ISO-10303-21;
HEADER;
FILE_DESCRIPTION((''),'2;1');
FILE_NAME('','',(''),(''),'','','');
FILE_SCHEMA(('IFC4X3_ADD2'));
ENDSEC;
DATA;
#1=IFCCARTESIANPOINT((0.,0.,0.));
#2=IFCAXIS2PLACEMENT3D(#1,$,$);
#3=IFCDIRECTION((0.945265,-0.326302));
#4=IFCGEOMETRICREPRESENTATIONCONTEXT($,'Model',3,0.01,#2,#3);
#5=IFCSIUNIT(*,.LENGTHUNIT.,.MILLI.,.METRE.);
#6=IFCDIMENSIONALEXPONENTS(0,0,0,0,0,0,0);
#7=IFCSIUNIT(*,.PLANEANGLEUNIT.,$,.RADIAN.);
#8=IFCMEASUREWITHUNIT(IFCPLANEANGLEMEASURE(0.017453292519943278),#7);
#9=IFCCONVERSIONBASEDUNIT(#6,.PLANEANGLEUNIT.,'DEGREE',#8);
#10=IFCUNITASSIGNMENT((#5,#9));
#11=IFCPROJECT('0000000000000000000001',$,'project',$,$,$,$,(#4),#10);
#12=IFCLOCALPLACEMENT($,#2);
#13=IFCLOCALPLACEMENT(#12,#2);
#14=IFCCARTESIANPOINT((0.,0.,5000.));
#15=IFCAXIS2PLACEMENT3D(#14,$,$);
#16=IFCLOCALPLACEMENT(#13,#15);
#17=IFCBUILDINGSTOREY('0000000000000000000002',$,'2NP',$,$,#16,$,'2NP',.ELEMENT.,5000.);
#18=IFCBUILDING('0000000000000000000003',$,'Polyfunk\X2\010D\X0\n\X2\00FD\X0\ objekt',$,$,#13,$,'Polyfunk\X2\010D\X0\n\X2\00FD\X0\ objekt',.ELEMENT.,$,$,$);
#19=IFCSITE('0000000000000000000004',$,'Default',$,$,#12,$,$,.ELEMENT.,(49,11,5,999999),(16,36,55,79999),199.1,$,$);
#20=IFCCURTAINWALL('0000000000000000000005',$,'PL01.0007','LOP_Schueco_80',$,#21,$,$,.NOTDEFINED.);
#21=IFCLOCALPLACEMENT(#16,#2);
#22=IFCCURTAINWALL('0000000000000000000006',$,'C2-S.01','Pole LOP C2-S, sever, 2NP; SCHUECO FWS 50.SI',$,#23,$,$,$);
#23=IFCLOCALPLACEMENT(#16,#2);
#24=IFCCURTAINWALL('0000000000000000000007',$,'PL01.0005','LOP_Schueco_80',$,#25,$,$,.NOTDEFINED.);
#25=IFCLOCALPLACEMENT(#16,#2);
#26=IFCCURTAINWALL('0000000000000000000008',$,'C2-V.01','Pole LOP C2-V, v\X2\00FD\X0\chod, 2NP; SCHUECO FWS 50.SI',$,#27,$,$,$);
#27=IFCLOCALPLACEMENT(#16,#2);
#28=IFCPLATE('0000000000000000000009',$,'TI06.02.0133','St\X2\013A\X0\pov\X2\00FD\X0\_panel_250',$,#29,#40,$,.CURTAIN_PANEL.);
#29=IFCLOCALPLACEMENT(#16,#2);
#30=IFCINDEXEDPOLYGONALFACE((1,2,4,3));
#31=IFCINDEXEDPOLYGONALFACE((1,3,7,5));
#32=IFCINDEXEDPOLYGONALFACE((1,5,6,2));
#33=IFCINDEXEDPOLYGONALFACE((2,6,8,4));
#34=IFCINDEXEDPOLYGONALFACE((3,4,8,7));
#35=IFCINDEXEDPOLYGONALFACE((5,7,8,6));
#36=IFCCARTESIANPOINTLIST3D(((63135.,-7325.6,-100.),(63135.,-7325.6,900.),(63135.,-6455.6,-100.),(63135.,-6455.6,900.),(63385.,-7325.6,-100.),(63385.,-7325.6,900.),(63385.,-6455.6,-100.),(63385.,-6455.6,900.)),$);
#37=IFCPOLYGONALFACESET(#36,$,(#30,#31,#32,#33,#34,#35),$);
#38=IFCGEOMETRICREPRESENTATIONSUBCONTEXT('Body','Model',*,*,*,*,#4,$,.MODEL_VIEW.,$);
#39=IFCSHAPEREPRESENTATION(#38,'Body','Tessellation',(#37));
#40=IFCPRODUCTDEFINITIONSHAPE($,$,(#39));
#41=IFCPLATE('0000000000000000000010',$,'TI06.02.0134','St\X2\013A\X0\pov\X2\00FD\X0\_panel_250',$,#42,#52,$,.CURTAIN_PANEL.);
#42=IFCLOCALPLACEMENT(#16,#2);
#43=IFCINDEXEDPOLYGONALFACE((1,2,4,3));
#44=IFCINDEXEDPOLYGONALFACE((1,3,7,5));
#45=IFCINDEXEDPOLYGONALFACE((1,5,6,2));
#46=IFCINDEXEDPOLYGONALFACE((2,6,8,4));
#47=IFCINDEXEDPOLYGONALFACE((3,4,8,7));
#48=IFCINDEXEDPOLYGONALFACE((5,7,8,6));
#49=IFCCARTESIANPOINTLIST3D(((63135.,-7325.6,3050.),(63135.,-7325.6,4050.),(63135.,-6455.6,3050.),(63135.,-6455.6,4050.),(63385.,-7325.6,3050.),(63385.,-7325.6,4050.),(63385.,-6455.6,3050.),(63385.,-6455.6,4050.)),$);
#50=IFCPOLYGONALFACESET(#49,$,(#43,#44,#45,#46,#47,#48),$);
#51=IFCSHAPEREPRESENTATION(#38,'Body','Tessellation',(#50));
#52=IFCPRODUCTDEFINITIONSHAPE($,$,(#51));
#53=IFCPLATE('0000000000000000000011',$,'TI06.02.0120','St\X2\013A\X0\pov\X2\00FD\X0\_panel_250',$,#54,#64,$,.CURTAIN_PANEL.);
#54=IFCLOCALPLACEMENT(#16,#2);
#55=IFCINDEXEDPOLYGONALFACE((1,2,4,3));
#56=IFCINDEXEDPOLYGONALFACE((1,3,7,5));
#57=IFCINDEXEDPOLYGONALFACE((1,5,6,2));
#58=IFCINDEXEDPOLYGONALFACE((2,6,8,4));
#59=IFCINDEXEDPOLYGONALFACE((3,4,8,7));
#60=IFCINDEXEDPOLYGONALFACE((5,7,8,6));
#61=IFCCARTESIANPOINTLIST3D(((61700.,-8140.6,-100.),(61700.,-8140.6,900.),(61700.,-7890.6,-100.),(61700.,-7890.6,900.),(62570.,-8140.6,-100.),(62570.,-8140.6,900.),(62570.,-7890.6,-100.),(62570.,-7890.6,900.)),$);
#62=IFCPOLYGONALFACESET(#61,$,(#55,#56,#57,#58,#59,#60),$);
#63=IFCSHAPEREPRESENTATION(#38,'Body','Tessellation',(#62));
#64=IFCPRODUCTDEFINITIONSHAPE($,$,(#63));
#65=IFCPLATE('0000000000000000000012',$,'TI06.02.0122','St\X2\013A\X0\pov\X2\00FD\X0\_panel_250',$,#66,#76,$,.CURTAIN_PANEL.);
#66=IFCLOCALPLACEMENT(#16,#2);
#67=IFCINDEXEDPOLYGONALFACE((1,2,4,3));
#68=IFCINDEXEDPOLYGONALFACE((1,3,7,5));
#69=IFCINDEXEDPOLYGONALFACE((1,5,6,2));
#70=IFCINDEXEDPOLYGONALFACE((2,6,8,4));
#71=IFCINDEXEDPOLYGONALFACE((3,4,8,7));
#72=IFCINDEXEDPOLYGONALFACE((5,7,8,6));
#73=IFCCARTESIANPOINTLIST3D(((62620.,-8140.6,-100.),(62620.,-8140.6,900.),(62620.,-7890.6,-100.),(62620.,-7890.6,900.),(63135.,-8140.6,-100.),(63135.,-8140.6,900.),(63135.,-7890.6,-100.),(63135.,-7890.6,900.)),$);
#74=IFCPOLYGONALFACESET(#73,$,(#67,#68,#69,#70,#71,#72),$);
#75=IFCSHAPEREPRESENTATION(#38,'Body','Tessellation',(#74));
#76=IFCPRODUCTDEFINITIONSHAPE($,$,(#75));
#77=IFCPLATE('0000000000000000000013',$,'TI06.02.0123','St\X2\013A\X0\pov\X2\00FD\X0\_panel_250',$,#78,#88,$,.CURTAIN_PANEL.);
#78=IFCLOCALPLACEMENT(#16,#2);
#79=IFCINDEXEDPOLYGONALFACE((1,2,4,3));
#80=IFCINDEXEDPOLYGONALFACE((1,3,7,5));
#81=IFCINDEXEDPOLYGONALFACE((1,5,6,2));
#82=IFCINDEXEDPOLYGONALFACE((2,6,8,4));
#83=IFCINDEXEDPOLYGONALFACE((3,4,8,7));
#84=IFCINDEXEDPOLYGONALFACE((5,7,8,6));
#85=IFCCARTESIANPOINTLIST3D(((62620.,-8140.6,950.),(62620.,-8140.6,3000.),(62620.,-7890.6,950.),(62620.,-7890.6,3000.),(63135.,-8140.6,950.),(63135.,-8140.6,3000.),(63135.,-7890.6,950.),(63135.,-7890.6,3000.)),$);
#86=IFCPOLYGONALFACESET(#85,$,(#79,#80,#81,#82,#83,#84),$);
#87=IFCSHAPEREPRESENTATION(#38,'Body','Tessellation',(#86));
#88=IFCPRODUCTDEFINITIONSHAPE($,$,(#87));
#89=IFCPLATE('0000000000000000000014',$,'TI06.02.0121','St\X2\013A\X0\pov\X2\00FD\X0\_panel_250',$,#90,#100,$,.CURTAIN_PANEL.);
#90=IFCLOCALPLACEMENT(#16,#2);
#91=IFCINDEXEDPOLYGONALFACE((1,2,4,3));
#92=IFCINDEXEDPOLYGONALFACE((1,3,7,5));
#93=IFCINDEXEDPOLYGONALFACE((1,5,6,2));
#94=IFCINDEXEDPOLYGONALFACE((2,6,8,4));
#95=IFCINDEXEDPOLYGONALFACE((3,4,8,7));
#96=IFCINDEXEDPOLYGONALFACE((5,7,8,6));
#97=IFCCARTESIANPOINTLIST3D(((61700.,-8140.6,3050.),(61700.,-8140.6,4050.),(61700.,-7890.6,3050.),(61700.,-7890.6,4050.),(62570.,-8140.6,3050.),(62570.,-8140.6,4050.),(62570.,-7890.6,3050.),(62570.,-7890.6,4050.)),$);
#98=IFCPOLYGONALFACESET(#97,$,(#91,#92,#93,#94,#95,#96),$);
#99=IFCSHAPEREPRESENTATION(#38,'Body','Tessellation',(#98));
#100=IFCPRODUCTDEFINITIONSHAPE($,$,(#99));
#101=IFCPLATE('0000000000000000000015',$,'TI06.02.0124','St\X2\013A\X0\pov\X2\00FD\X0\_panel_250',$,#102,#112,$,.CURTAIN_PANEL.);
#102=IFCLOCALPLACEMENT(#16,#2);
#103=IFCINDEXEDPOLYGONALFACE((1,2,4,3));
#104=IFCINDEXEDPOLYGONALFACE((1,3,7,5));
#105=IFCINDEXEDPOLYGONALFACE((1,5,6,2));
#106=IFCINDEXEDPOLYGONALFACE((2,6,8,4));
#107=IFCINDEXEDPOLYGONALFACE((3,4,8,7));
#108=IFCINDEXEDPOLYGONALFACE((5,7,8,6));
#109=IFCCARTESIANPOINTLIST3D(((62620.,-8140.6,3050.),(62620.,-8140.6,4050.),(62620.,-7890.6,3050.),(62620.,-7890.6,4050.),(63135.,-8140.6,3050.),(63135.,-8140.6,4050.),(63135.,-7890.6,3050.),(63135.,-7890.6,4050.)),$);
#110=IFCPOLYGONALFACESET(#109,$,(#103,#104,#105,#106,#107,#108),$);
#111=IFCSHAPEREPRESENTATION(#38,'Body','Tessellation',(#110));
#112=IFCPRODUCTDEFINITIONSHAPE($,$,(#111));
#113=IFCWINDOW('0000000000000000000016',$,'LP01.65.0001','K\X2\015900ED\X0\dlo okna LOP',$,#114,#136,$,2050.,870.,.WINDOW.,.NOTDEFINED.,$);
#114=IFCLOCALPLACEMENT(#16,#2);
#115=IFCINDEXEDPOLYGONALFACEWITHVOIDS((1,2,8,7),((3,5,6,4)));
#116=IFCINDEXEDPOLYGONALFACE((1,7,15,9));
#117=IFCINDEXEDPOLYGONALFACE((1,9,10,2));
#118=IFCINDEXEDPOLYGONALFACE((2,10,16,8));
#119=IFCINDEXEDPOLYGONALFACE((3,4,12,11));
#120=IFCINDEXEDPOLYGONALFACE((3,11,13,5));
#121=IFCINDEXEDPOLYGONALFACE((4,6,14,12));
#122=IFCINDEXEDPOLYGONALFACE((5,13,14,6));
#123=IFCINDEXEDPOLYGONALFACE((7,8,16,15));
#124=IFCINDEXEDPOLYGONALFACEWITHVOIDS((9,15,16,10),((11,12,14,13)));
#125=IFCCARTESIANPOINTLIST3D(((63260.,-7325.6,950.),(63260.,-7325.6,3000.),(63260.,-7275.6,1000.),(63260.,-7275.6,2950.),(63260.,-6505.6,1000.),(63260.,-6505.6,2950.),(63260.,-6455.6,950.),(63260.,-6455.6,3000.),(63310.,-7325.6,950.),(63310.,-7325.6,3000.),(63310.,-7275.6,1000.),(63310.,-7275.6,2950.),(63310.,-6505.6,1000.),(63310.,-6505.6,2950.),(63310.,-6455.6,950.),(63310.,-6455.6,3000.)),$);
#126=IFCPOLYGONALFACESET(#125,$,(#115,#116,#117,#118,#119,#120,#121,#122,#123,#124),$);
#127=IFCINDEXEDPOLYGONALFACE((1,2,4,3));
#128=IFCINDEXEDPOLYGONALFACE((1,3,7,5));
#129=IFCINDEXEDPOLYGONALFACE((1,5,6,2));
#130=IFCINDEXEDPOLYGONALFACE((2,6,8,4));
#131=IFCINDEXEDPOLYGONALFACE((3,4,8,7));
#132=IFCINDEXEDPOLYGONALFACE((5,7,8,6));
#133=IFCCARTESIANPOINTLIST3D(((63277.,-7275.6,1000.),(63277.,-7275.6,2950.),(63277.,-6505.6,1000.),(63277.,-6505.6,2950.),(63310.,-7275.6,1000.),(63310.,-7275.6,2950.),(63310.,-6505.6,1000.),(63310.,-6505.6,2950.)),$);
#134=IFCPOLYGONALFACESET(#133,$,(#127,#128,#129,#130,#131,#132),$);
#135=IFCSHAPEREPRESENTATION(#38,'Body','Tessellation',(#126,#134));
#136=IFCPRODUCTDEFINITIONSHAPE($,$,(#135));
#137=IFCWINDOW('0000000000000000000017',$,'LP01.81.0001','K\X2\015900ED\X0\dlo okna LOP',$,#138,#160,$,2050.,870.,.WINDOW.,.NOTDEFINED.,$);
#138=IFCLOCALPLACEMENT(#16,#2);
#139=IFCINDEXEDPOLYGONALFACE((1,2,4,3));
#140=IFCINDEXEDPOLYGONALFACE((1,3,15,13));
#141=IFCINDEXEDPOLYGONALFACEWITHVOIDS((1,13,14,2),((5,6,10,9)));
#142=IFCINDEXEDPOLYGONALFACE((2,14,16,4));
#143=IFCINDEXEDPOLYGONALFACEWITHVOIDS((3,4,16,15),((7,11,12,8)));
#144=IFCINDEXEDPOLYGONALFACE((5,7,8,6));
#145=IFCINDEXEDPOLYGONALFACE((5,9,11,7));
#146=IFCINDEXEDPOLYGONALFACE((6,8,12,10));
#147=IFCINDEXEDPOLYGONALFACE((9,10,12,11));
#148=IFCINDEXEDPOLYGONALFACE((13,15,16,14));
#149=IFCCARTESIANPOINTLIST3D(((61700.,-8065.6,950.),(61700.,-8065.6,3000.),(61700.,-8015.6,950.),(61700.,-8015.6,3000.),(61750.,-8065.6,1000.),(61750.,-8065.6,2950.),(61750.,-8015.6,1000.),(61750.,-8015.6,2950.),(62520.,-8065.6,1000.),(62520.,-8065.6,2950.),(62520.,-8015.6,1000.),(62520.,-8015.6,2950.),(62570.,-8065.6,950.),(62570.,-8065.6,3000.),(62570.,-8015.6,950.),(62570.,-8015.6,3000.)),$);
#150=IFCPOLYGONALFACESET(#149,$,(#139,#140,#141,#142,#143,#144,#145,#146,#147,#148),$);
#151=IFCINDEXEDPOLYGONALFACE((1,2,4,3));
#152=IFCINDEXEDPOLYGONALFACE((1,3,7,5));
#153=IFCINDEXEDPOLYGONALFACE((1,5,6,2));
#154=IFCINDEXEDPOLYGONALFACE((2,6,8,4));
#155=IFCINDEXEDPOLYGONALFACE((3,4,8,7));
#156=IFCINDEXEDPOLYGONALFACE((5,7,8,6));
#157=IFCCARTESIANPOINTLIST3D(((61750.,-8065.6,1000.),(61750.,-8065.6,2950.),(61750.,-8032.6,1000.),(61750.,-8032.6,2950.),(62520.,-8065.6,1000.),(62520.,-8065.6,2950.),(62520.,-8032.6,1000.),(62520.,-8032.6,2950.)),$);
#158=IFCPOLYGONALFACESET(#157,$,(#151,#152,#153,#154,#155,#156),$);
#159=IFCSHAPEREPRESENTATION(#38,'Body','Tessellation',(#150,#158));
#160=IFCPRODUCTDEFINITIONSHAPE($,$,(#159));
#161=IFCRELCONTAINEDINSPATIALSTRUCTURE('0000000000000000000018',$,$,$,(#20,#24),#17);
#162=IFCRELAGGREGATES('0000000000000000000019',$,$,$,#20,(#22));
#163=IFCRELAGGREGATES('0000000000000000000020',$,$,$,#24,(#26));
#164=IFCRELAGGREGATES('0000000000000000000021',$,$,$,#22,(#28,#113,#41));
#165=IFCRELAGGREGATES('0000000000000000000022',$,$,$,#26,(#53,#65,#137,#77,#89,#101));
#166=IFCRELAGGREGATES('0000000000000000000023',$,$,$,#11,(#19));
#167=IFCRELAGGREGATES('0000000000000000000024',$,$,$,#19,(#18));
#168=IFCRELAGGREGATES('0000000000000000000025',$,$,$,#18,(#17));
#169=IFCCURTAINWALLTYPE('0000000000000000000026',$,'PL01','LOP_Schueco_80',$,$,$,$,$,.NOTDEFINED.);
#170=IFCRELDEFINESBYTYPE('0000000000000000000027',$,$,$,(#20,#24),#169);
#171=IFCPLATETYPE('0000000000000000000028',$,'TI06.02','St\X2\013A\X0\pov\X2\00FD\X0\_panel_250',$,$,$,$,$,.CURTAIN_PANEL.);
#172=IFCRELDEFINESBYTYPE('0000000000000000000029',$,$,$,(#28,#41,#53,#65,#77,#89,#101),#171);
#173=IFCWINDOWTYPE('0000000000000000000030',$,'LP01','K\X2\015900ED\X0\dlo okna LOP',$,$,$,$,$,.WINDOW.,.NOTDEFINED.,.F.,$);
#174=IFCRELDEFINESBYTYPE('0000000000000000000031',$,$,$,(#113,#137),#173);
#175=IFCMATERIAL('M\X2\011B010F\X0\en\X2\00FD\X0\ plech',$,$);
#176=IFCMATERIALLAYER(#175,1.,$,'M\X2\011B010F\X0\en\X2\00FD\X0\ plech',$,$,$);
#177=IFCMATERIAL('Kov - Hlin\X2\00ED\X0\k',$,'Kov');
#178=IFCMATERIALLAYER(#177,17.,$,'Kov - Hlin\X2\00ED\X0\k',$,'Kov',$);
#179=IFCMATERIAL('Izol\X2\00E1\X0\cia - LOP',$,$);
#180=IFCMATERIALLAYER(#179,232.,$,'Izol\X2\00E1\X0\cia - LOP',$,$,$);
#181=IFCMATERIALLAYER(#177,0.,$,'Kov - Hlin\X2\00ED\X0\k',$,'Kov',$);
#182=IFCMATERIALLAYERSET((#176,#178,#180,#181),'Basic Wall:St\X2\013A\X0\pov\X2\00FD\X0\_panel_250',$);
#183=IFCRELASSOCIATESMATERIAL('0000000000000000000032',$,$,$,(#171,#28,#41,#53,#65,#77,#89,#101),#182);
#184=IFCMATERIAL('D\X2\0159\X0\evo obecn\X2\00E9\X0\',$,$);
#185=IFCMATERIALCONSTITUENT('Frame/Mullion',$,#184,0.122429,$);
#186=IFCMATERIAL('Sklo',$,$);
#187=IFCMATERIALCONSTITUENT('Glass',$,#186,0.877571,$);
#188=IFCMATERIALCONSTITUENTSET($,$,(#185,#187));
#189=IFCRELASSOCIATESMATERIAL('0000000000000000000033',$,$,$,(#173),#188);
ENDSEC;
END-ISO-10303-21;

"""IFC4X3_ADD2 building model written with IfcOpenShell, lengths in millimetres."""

from ifc_helpers import new_model, entity, si_unit, converted_unit, direction, frame, frame_2d, origin, origin_2d_with_axis, place, context, subcontext, project, spatial, polyline, rectangle, outline, extrude, source, transform, mapped, material, layer, layer_set, layer_usage, constituent, constituent_set, type_object, type_shapes, element, aggregate, save


model = new_model("IFC4X3_ADD2")

# Units and contexts
model_context = context("Model", 3, precision=0.01, world=origin(), true_north=direction((0.945265, -0.326302)))
body_context = subcontext(model_context, "Body", "Model", "MODEL_VIEW")
ifc_project = project(units=[si_unit("LENGTHUNIT", "METRE", prefix="MILLI"), converted_unit("PLANEANGLEUNIT", "DEGREE", entity("IfcPlaneAngleMeasure", 0.017453292519943278), si_unit("PLANEANGLEUNIT", "RADIAN"), dimensions=[0, 0, 0, 0, 0, 0, 0])], contexts=[model_context])

# Site, building, storey
site_placement = place(None, origin())
site = spatial("IfcSite", under=ifc_project, at=site_placement, Name="Default", CompositionType="ELEMENT", RefLatitude=(49, 11, 5, 999999), RefLongitude=(16, 36, 55, 79999), RefElevation=199.1)
building_placement = place(site_placement, origin())
building = spatial("IfcBuilding", under=site, at=building_placement, Name="Polyfunkčný objekt", LongName="Polyfunkčný objekt", CompositionType="ELEMENT")
storey_placement = place(building_placement, frame((0.0, 0.0, 5000.0)))
storey = spatial("IfcBuildingStorey", under=building, at=storey_placement, Name="2NP", LongName="2NP", CompositionType="ELEMENT", Elevation=5000.0)

# Curtain walls
curtain_wall_type = type_object("IfcCurtainWallType", Name="PL01", Description="LOP_Schueco_80", PredefinedType="NOTDEFINED")
curtain_wall_1_placement = place(storey_placement, frame((0.0, 0.0, -5000.0)))
curtain_wall_1 = element("IfcCurtainWall", 1, at=curtain_wall_1_placement, inside=storey, type_object=curtain_wall_type, Name="PL01.0007", Description="LOP_Schueco_80", PredefinedType="NOTDEFINED")
curtain_wall_2 = element("IfcCurtainWall", 2, Name="C2-S.01", Description="Pole LOP C2-S, sever, 2NP; SCHUECO FWS 50.SI")
aggregate(curtain_wall_1, [curtain_wall_2])
curtain_wall_3_placement = place(storey_placement, frame((0.0, 0.0, -5000.0)))
curtain_wall_3 = element("IfcCurtainWall", 3, at=curtain_wall_3_placement, inside=storey, type_object=curtain_wall_type, Name="PL01.0005", Description="LOP_Schueco_80", PredefinedType="NOTDEFINED")
curtain_wall_4 = element("IfcCurtainWall", 4, Name="C2-V.01", Description="Pole LOP C2-V, východ, 2NP; SCHUECO FWS 50.SI")
aggregate(curtain_wall_3, [curtain_wall_4])

# Plates
ifc_material_1 = material(Name="Měďený plech")
ifc_layer_1 = layer(ifc_material_1, 1.0, Name="Měďený plech")
ifc_material_2 = material(Name="Kov - Hliník", Category="Kov")
ifc_layer_2 = layer(ifc_material_2, 17.0, Name="Kov - Hliník", Category="Kov")
ifc_material_3 = material(Name="Izolácia - LOP")
ifc_layer_3 = layer(ifc_material_3, 232.0, Name="Izolácia - LOP")
ifc_layer_4 = layer(ifc_material_2, 0.0, Name="Kov - Hliník", Category="Kov")
ifc_layer_set = layer_set([ifc_layer_1, ifc_layer_2, ifc_layer_3, ifc_layer_4], Name="Basic Wall:Stĺpový_panel_250")
ifc_layer_usage_1 = layer_usage(ifc_layer_set, "AXIS2", "NEGATIVE", 125.0)
plate_type = type_object("IfcPlateType", Name="TI06.02", Description="Stĺpový_panel_250", PredefinedType="CURTAIN_PANEL", material=ifc_layer_set)
plate_1_placement = place(storey_placement, frame((63260.0, -6455.6, -100.0), z_axis=(0.0, 0.0, 1.0), x_axis=(0.0, -1.0, 0.0)))
plate_1 = element("IfcPlate", 5, at=plate_1_placement, type_object=plate_type, material=ifc_layer_usage_1, Name="TI06.02.0133", Description="Stĺpový_panel_250", PredefinedType="CURTAIN_PANEL", context=body_context, shape_type="SweptSolid", body=[
    extrude(rectangle(XDim=250.0, YDim=870.0, at=frame_2d((0.0, 0.0), x_axis=(1.0, 0.0))), frame((435.0, 0.0, 0.0), z_axis=(0.0, 0.0, 1.0), x_axis=(0.0, 1.0, 0.0)), (0.0, 0.0, 1.0), 1000.0),
])
ifc_layer_usage_2 = layer_usage(ifc_layer_set, "AXIS2", "NEGATIVE", 125.0)
plate_2_placement = place(storey_placement, frame((63260.0, -6455.6, 3050.0), z_axis=(0.0, 0.0, 1.0), x_axis=(0.0, -1.0, 0.0)))
plate_2 = element("IfcPlate", 6, at=plate_2_placement, type_object=plate_type, material=ifc_layer_usage_2, Name="TI06.02.0134", Description="Stĺpový_panel_250", PredefinedType="CURTAIN_PANEL", context=body_context, shape_type="SweptSolid", body=[
    extrude(rectangle(XDim=250.0, YDim=870.0, at=frame_2d((0.0, 0.0), x_axis=(1.0, 0.0))), frame((435.0, 0.0, 0.0), z_axis=(0.0, 0.0, 1.0), x_axis=(0.0, 1.0, 0.0)), (0.0, 0.0, 1.0), 1000.0),
])
ifc_layer_usage_3 = layer_usage(ifc_layer_set, "AXIS2", "POSITIVE", -125.0)
plate_3_placement = place(storey_placement, frame((61700.0, -8015.6, -100.0)))
plate_3 = element("IfcPlate", 7, at=plate_3_placement, type_object=plate_type, material=ifc_layer_usage_3, Name="TI06.02.0120", Description="Stĺpový_panel_250", PredefinedType="CURTAIN_PANEL", context=body_context, shape_type="SweptSolid", body=[
    extrude(rectangle(XDim=250.0, YDim=870.0, at=frame_2d((0.0, 0.0), x_axis=(1.0, 0.0))), frame((435.0, 0.0, 0.0), z_axis=(0.0, 0.0, 1.0), x_axis=(0.0, 1.0, 0.0)), (0.0, 0.0, 1.0), 1000.0),
])
ifc_layer_usage_4 = layer_usage(ifc_layer_set, "AXIS2", "POSITIVE", -125.0)
plate_4_placement = place(storey_placement, frame((62620.0, -8015.6, -100.0)))
plate_4 = element("IfcPlate", 8, at=plate_4_placement, type_object=plate_type, material=ifc_layer_usage_4, Name="TI06.02.0122", Description="Stĺpový_panel_250", PredefinedType="CURTAIN_PANEL", context=body_context, shape_type="SweptSolid", body=[
    extrude(rectangle(XDim=250.0, YDim=515.0, at=frame_2d((0.0, 0.0), x_axis=(1.0, 0.0))), frame((257.5, 0.0, 0.0), z_axis=(0.0, 0.0, 1.0), x_axis=(0.0, 1.0, 0.0)), (0.0, 0.0, 1.0), 1000.0),
])
ifc_layer_usage_5 = layer_usage(ifc_layer_set, "AXIS2", "POSITIVE", -125.0)
plate_5_placement = place(storey_placement, frame((62620.0, -8015.6, 950.0)))
plate_5 = element("IfcPlate", 9, at=plate_5_placement, type_object=plate_type, material=ifc_layer_usage_5, Name="TI06.02.0123", Description="Stĺpový_panel_250", PredefinedType="CURTAIN_PANEL", context=body_context, shape_type="SweptSolid", body=[
    extrude(rectangle(XDim=250.0, YDim=515.0, at=frame_2d((0.0, 0.0), x_axis=(1.0, 0.0))), frame((257.5, 0.0, 0.0), z_axis=(0.0, 0.0, 1.0), x_axis=(0.0, 1.0, 0.0)), (0.0, 0.0, 1.0), 2050.0),
])
ifc_layer_usage_6 = layer_usage(ifc_layer_set, "AXIS2", "POSITIVE", -125.0)
plate_6_placement = place(storey_placement, frame((61700.0, -8015.6, 3050.0)))
plate_6 = element("IfcPlate", 10, at=plate_6_placement, type_object=plate_type, material=ifc_layer_usage_6, Name="TI06.02.0121", Description="Stĺpový_panel_250", PredefinedType="CURTAIN_PANEL", context=body_context, shape_type="SweptSolid", body=[
    extrude(rectangle(XDim=250.0, YDim=870.0, at=frame_2d((0.0, 0.0), x_axis=(1.0, 0.0))), frame((435.0, 0.0, 0.0), z_axis=(0.0, 0.0, 1.0), x_axis=(0.0, 1.0, 0.0)), (0.0, 0.0, 1.0), 1000.0),
])
ifc_layer_usage_7 = layer_usage(ifc_layer_set, "AXIS2", "POSITIVE", -125.0)
plate_7_placement = place(storey_placement, frame((62620.0, -8015.6, 3050.0)))
plate_7 = element("IfcPlate", 11, at=plate_7_placement, type_object=plate_type, material=ifc_layer_usage_7, Name="TI06.02.0124", Description="Stĺpový_panel_250", PredefinedType="CURTAIN_PANEL", context=body_context, shape_type="SweptSolid", body=[
    extrude(rectangle(XDim=250.0, YDim=515.0, at=frame_2d((0.0, 0.0), x_axis=(1.0, 0.0))), frame((257.5, 0.0, 0.0), z_axis=(0.0, 0.0, 1.0), x_axis=(0.0, 1.0, 0.0)), (0.0, 0.0, 1.0), 1000.0),
])

# Windows
ifc_material_4 = material(Name="Dřevo obecné")
ifc_constituent_1 = constituent(ifc_material_4, Name="Frame/Mullion", fraction=0.122429)
ifc_material_5 = material(Name="Sklo")
ifc_constituent_2 = constituent(ifc_material_5, Name="Glass", fraction=0.877571)
ifc_constituent_set = constituent_set(constituents=[ifc_constituent_1, ifc_constituent_2])
window_type = type_object("IfcWindowType", Name="LP01", Description="Křídlo okna LOP", ParameterTakesPrecedence=False, PartitioningType="NOTDEFINED", PredefinedType="WINDOW", material=ifc_constituent_set)
shared_shape_1 = source(origin(), body_context, "Body", "SweptSolid", [
    extrude(outline(polyline([(-1025.0, -435.0), (1025.0, -435.0), (1025.0, 435.0), (-1025.0, 435.0), (-1025.0, -435.0)]), holes=[polyline([(-975.0, -385.0), (-975.0, 385.0), (975.0, 385.0), (975.0, -385.0), (-975.0, -385.0)])]), frame((0.0, 0.0, 1025.0), z_axis=(0.0, 1.0, 0.0), x_axis=(0.0, 0.0, -1.0)), (0.0, 0.0, 1.0), 50.0),
    extrude(rectangle(XDim=33.0, YDim=770.0, at=origin_2d_with_axis()), frame((0.0, 33.5, 50.0), z_axis=(0.0, 0.0, 1.0), x_axis=(0.0, -1.0, 0.0)), (0.0, 0.0, 1.0), 1950.0),
])
window_1_placement = place(curtain_wall_1_placement, frame((63260.0, -6890.6, 5950.0), z_axis=(0.0, 0.0, 1.0), x_axis=(0.0, -1.0, 0.0)))
window_1 = element("IfcWindow", 12, at=window_1_placement, type_object=window_type, Name="LP01.65.0001", Description="Křídlo okna LOP", OverallHeight=2050.0, OverallWidth=870.0, PartitioningType="NOTDEFINED", PredefinedType="WINDOW", context=body_context, shape_type="MappedRepresentation", body=[
    mapped(shared_shape_1, transform((0.0, 0.0, 0.0), scale=1.0)),
])
aggregate(curtain_wall_2, [plate_1, window_1, plate_2])
shared_shape_2 = source(origin(), body_context, "Body", "SweptSolid", [
    extrude(outline(polyline([(-1025.0, -435.0), (1025.0, -435.0), (1025.0, 435.0), (-1025.0, 435.0), (-1025.0, -435.0)]), holes=[polyline([(-975.0, -385.0), (-975.0, 385.0), (975.0, 385.0), (975.0, -385.0), (-975.0, -385.0)])]), frame((0.0, 50.0, 1025.0), z_axis=(0.0, -1.0, 0.0), x_axis=(0.0, 0.0, -1.0)), (0.0, 0.0, 1.0), 50.0),
    extrude(rectangle(XDim=770.0, YDim=33.0, at=frame_2d((0.0, 0.0), x_axis=(1.0, 0.0))), frame((0.0, 33.5, 50.0), z_axis=(0.0, 0.0, 1.0), x_axis=(-1.0, 0.0, 0.0)), (0.0, 0.0, 1.0), 1950.0),
])
type_shapes(window_type, [shared_shape_1, shared_shape_2])
window_2_placement = place(curtain_wall_3_placement, frame((62135.0, -8015.6, 5950.0), z_axis=(0.0, 0.0, 1.0), x_axis=(-1.0, 0.0, 0.0)))
window_2 = element("IfcWindow", 13, at=window_2_placement, type_object=window_type, Name="LP01.81.0001", Description="Křídlo okna LOP", OverallHeight=2050.0, OverallWidth=870.0, PartitioningType="NOTDEFINED", PredefinedType="WINDOW", context=body_context, shape_type="MappedRepresentation", body=[
    mapped(shared_shape_2, transform((0.0, 0.0, 0.0), scale=1.0)),
])
aggregate(curtain_wall_4, [plate_3, plate_4, window_2, plate_5, plate_6, plate_7])

save(model, "model.ifc")
